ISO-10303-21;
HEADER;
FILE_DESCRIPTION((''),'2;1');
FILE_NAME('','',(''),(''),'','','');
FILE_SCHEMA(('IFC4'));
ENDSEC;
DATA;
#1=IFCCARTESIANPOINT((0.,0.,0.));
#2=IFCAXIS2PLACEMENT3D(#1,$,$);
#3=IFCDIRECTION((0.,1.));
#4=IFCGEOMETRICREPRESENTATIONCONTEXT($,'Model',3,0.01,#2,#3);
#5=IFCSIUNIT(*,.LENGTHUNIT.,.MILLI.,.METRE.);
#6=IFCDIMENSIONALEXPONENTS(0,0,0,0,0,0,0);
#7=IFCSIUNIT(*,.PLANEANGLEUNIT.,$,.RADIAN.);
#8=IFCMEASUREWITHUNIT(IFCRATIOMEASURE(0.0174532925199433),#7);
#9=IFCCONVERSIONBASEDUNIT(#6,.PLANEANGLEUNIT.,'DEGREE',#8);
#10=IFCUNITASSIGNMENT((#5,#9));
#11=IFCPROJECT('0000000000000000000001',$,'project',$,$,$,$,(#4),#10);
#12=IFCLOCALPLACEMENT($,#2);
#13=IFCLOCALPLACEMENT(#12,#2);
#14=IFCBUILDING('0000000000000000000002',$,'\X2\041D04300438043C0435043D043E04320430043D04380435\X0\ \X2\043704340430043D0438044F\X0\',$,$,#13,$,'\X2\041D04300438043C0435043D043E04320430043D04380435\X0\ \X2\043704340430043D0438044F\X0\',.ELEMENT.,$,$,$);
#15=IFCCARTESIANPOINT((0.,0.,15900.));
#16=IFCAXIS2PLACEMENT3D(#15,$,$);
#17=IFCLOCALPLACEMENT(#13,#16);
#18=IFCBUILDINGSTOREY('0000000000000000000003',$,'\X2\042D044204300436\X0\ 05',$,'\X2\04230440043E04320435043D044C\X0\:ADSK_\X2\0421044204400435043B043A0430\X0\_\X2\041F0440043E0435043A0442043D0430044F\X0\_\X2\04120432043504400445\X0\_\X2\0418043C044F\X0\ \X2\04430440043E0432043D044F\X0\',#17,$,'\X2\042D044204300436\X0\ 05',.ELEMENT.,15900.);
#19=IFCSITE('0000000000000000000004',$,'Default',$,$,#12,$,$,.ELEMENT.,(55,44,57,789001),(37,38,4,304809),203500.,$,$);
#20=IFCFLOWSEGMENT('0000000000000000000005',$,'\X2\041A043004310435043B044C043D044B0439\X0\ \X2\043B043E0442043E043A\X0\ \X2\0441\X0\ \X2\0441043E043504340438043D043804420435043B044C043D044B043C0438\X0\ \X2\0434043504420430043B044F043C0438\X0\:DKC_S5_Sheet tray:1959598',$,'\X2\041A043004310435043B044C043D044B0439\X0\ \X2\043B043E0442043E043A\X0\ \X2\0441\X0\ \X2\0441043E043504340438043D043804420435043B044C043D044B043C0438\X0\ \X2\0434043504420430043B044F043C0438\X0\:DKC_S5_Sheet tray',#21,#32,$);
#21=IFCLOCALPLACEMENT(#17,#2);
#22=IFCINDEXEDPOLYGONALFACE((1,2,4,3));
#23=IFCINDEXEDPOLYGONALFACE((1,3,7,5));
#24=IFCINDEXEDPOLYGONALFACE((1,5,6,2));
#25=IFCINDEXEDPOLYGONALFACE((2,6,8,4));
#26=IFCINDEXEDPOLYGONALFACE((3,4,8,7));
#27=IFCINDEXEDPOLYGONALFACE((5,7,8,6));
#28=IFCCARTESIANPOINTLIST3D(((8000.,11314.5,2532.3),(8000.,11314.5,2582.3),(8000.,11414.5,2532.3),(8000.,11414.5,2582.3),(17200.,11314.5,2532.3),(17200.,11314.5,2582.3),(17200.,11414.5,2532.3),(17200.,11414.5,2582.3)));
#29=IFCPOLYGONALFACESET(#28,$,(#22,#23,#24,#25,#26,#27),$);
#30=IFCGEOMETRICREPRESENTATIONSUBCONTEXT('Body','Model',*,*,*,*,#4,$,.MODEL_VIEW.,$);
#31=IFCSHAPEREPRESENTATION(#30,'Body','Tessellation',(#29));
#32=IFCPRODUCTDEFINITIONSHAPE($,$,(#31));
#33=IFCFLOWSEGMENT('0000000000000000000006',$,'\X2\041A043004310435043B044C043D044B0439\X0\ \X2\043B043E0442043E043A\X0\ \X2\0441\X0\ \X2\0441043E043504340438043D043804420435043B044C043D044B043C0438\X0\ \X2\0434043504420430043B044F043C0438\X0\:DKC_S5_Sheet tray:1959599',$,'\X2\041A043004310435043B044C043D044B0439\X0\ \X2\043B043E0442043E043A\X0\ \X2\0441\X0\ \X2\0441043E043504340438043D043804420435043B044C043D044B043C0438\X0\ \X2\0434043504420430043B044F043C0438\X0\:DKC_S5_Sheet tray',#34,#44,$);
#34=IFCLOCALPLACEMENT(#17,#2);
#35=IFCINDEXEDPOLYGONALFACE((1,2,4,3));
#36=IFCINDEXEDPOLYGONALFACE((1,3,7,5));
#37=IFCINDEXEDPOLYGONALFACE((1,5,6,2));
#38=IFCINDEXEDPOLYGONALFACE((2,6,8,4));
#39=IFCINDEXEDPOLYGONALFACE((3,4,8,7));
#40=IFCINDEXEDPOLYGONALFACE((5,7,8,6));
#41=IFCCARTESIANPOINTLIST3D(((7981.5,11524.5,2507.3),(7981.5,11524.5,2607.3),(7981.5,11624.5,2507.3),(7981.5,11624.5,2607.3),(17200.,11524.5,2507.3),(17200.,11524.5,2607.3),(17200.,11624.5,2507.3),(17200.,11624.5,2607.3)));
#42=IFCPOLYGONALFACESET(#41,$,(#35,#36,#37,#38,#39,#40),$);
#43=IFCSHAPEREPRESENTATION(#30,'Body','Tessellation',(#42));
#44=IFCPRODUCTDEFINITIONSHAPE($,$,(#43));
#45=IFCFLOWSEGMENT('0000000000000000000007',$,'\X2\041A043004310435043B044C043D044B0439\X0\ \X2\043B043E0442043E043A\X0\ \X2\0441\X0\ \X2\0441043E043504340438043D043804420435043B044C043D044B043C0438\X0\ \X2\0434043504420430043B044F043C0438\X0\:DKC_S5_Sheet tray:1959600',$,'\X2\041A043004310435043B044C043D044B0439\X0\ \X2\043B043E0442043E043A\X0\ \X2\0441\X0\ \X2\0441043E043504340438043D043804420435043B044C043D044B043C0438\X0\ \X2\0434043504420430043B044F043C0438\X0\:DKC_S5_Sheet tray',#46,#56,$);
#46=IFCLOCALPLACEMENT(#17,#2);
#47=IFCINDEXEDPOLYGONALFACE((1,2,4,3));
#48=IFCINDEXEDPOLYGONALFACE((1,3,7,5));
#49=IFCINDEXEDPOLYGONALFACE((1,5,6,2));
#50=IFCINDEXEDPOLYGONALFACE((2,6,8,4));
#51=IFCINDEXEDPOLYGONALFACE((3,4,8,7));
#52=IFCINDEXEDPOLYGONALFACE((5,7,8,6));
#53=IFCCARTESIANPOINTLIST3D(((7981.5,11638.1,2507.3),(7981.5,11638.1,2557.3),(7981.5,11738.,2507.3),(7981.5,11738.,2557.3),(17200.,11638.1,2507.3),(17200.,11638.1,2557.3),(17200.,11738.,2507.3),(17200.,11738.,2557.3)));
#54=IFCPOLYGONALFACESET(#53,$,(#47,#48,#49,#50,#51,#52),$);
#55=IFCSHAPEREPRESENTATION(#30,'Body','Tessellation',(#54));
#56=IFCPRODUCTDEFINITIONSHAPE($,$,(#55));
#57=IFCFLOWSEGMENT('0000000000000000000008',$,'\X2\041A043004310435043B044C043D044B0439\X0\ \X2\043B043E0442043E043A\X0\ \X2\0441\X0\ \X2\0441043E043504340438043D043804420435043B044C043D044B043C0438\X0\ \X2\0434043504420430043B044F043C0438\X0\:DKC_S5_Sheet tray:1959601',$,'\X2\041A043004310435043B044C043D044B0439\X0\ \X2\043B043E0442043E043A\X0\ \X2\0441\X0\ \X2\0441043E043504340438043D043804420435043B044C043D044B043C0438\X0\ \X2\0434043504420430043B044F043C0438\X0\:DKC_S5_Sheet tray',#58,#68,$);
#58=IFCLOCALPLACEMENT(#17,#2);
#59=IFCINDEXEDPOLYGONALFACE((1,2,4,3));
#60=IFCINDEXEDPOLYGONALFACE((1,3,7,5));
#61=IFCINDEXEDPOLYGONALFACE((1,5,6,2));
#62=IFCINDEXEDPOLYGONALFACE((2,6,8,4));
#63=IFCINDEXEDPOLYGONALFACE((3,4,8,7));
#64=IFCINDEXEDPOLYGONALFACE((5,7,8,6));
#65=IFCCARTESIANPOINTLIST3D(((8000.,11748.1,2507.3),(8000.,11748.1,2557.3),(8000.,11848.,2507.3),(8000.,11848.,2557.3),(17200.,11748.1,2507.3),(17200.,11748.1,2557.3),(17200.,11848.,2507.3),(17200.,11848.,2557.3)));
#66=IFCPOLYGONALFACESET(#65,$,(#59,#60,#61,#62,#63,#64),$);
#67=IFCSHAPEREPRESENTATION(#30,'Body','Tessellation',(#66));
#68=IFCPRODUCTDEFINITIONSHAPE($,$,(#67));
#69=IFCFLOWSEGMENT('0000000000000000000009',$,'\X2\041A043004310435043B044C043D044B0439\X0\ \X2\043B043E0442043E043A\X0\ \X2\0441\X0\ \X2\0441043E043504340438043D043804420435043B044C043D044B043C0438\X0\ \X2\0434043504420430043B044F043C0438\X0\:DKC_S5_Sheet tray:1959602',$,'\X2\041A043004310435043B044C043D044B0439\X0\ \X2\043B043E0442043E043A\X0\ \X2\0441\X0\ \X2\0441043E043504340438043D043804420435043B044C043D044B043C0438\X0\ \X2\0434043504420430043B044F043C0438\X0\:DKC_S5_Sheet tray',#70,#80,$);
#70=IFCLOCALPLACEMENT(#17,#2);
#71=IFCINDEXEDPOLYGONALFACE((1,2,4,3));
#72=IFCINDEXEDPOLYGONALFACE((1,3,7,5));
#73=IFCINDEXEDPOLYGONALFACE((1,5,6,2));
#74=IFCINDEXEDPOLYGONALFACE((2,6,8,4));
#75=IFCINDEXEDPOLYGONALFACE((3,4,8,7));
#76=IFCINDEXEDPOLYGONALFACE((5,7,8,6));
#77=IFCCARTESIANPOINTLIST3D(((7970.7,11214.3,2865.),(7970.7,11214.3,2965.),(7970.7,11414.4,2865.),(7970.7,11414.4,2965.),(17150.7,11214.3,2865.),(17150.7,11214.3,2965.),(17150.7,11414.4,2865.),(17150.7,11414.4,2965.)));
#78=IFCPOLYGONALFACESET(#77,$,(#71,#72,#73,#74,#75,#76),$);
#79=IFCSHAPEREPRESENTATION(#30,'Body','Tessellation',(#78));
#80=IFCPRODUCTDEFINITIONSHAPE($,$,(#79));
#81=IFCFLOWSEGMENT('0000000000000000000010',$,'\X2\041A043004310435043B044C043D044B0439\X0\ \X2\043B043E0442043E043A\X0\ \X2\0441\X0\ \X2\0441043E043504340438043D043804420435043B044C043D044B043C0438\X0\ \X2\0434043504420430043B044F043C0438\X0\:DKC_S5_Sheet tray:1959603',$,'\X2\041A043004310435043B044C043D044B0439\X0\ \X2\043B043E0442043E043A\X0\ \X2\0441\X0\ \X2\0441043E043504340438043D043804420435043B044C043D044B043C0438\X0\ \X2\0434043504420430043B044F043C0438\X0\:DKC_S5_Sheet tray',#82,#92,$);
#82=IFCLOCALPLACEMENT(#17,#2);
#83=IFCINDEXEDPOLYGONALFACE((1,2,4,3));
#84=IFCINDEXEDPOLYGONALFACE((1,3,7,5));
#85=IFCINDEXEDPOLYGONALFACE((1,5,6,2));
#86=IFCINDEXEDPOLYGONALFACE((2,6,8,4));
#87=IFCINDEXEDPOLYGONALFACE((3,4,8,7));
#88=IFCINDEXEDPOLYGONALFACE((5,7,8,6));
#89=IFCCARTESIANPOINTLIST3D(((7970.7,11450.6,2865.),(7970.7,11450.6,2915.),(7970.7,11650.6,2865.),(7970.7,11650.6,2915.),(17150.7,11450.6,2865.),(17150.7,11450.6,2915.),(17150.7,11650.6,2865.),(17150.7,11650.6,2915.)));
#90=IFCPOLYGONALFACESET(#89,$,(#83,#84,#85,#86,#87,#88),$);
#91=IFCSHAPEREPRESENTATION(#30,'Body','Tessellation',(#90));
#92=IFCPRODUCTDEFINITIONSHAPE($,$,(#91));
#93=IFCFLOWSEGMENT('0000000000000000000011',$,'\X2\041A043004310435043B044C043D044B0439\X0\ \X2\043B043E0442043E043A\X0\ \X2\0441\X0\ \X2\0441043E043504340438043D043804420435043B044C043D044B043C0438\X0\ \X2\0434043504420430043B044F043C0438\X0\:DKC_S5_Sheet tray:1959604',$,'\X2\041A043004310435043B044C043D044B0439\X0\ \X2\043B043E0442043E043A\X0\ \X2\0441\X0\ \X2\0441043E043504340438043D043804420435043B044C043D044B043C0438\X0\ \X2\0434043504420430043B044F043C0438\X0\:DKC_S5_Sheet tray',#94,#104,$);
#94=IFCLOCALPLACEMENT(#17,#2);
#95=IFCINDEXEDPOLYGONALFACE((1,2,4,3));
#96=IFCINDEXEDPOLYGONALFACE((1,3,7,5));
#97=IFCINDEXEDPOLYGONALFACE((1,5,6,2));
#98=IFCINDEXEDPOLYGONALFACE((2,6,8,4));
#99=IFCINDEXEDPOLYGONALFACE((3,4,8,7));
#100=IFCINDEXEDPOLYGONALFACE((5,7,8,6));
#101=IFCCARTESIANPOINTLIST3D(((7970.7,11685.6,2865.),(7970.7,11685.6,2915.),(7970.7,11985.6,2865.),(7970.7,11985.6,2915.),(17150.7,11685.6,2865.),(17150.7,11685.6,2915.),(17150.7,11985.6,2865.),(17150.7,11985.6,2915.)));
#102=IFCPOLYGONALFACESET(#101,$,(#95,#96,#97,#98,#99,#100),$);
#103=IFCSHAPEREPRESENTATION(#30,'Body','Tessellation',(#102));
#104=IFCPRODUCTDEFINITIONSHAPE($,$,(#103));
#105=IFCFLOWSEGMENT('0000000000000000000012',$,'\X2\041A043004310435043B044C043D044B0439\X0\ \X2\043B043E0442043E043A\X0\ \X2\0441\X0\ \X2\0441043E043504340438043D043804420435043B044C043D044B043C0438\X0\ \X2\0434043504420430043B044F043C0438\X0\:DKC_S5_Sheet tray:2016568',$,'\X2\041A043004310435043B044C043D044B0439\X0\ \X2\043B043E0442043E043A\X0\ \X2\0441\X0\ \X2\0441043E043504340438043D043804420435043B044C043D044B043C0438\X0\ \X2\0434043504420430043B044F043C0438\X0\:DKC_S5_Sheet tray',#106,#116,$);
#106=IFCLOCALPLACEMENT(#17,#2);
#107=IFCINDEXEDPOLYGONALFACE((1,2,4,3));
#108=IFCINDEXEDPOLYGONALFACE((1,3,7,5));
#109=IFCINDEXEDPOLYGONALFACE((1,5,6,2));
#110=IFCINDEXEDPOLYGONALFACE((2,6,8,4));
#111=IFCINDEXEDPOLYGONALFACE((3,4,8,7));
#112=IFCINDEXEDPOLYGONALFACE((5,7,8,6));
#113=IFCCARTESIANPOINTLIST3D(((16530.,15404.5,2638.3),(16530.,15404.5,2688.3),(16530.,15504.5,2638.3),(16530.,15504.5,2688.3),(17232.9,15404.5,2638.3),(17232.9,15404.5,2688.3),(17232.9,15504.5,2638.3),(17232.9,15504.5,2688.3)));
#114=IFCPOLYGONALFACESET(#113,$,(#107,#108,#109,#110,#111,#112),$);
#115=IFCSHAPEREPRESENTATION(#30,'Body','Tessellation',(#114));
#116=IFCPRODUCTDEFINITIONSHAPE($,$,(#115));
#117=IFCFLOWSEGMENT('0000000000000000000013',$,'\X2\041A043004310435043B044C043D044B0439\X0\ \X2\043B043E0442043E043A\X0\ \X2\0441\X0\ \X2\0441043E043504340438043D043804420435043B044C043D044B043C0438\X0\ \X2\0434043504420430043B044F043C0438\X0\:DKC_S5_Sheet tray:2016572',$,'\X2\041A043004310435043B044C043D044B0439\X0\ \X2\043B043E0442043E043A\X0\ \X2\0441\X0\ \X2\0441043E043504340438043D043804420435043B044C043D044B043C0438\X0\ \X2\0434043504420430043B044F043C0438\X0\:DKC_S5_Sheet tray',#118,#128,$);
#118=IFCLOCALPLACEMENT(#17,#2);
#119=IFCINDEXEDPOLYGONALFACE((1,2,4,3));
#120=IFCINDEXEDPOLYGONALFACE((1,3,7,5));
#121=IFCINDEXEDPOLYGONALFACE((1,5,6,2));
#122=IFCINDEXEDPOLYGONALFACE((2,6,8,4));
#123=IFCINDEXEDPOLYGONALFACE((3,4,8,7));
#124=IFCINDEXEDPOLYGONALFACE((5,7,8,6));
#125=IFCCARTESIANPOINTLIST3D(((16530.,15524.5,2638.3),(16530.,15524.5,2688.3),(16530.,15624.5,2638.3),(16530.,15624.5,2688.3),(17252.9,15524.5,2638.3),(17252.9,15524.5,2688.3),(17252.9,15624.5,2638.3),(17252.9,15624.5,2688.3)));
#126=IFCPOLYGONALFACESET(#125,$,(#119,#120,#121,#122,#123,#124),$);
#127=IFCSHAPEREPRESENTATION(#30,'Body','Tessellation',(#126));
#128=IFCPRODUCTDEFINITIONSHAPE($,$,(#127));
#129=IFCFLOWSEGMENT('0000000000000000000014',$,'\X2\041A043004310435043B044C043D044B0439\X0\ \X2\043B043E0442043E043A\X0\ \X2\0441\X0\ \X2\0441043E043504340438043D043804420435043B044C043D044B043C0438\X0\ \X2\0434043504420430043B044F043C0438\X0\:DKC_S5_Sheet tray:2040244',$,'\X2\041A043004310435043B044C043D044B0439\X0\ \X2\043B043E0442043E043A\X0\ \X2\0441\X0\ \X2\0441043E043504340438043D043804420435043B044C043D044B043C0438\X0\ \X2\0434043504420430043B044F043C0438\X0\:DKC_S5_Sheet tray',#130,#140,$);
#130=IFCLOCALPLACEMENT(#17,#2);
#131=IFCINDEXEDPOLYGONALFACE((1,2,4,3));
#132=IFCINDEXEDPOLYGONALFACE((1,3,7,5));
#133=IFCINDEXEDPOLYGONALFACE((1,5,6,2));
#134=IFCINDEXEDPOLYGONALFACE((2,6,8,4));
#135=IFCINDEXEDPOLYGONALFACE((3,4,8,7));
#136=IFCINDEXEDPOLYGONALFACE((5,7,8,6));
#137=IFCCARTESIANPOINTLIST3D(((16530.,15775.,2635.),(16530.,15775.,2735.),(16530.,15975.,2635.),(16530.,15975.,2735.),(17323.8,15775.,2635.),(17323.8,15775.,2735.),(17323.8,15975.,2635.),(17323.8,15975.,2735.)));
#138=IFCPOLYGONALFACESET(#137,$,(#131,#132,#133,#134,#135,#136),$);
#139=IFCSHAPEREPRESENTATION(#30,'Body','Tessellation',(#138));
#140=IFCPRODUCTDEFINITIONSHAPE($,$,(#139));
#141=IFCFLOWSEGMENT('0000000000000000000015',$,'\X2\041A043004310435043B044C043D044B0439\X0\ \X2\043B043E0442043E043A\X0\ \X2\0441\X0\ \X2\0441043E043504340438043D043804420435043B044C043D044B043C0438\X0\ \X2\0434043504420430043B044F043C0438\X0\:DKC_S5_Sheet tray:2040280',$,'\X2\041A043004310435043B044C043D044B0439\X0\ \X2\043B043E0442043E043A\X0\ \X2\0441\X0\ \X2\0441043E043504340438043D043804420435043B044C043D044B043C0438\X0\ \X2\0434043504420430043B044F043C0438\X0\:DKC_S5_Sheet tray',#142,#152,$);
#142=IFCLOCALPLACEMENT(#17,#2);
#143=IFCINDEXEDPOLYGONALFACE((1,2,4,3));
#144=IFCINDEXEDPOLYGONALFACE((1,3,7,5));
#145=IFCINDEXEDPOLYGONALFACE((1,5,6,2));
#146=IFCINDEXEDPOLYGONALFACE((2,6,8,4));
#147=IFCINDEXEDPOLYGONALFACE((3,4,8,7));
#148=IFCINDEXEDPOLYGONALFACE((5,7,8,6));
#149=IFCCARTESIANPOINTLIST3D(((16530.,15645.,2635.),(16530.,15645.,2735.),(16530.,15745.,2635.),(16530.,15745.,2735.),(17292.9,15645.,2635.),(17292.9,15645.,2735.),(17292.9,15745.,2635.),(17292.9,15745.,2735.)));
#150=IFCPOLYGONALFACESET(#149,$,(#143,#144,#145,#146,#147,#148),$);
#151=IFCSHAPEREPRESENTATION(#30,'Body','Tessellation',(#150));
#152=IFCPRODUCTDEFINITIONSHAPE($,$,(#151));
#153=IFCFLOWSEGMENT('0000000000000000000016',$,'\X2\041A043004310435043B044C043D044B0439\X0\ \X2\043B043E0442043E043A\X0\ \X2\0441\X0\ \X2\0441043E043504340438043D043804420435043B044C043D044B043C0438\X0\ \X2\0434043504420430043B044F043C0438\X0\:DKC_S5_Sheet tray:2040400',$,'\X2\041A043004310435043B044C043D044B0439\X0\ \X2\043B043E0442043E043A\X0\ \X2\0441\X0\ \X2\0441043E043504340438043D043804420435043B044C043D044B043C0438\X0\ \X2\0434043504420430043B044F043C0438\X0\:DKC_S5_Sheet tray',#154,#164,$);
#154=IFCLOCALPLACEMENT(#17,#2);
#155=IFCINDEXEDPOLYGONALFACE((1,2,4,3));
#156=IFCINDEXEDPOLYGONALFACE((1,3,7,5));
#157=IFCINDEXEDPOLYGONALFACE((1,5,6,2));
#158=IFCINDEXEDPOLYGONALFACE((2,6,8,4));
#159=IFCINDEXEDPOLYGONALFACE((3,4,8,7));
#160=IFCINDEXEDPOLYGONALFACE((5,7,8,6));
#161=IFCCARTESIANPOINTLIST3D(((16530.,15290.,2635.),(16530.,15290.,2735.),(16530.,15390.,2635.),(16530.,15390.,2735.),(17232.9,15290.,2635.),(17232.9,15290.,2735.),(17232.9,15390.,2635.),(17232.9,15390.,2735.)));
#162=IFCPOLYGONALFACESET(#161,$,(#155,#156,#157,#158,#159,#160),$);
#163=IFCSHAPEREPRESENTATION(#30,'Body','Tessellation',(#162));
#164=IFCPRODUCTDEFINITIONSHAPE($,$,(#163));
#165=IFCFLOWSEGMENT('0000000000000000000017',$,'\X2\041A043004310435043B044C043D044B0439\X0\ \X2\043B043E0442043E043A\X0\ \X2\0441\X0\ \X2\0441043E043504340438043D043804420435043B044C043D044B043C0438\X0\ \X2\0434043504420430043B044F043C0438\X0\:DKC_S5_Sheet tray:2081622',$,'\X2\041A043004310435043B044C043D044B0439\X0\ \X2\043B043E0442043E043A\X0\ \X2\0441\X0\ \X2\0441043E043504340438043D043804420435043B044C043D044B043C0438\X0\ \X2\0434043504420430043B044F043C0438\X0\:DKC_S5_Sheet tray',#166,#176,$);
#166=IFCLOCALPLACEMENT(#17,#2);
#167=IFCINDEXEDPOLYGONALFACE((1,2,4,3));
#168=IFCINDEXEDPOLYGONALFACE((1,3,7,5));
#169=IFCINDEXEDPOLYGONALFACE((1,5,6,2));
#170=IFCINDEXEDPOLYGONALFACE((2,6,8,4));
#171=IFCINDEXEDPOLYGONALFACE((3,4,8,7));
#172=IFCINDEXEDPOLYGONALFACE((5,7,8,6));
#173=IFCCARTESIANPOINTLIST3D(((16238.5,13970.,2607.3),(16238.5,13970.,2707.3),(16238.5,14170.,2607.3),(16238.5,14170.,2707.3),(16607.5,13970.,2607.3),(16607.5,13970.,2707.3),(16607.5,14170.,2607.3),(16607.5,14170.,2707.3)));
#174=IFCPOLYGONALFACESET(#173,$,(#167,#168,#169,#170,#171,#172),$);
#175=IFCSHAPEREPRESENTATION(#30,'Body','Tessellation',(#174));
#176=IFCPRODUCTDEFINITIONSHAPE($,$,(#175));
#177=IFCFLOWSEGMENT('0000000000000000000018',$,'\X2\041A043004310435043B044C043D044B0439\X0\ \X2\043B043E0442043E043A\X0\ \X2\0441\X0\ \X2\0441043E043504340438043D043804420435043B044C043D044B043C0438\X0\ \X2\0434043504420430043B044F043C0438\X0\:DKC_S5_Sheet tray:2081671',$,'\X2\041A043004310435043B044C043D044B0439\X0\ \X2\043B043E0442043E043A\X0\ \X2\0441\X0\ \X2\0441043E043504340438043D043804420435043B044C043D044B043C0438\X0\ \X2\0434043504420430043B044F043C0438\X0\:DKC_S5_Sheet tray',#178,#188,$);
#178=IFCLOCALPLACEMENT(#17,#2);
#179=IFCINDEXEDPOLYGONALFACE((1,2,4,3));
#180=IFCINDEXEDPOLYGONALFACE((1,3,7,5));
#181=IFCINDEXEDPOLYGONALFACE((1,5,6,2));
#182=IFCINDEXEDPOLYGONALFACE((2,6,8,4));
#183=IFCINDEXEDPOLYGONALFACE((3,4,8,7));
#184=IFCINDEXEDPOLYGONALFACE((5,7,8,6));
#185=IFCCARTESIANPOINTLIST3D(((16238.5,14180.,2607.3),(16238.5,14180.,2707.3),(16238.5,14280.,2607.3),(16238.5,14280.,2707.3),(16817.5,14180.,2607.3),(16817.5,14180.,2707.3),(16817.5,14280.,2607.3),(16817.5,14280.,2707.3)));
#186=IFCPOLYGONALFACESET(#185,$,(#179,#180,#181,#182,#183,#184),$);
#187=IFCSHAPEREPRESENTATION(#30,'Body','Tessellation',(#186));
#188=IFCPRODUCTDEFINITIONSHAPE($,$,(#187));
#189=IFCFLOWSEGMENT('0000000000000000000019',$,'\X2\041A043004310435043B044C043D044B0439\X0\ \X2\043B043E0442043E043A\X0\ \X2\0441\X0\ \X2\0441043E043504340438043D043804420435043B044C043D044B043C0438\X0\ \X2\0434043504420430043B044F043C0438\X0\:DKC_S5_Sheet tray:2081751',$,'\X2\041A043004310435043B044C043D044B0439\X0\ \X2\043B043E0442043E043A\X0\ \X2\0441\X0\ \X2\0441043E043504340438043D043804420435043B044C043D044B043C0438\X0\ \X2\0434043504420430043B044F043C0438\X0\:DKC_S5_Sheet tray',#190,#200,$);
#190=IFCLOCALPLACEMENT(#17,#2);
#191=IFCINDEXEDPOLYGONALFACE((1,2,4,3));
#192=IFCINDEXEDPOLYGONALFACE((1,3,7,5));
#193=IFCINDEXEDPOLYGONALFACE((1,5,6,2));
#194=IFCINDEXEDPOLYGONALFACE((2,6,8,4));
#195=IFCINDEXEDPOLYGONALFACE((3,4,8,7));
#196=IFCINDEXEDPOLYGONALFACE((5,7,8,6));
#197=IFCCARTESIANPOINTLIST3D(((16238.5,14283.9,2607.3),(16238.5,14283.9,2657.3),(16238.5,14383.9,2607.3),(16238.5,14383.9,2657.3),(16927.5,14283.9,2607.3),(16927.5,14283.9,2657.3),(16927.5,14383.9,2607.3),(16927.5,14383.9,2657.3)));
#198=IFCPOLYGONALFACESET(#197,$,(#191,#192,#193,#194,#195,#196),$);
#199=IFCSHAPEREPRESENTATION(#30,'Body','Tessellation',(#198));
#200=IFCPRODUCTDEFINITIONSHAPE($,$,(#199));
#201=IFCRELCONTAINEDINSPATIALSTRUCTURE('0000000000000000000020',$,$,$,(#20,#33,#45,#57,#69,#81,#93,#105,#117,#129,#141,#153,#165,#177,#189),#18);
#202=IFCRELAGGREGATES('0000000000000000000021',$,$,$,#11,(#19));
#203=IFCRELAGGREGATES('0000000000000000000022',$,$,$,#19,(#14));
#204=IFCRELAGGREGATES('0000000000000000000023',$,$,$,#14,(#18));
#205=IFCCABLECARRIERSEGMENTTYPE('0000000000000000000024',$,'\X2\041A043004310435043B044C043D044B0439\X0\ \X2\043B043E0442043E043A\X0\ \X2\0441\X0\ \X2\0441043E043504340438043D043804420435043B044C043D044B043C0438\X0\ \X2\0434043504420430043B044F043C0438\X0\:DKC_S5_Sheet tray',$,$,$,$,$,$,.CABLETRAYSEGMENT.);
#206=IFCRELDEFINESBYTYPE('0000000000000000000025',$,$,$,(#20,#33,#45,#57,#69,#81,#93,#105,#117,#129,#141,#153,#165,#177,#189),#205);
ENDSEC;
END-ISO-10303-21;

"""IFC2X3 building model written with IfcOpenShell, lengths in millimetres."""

from ifc_helpers import new_model, entity, si_unit, converted_unit, direction, frame, origin, origin_2d_with_axis, place, context, subcontext, project, spatial, rectangle, extrude, type_object, element, save


model = new_model("IFC2X3")

# Units and contexts
model_context = context("Model", 3, precision=0.01, world=origin(), true_north=direction((0.0, 1.0)))
body_context = subcontext(model_context, "Body", "Model", "MODEL_VIEW")
ifc_project = project(units=[si_unit("LENGTHUNIT", "METRE", prefix="MILLI"), converted_unit("PLANEANGLEUNIT", "DEGREE", entity("IfcRatioMeasure", 0.0174532925199433), si_unit("PLANEANGLEUNIT", "RADIAN"), dimensions=[0, 0, 0, 0, 0, 0, 0])], contexts=[model_context])

# Site, building, storey
site_placement = place(None, origin())
site = spatial("IfcSite", under=ifc_project, at=site_placement, Name="Default", CompositionType="ELEMENT", RefLatitude=(55, 44, 57, 789001), RefLongitude=(37, 38, 4, 304809), RefElevation=203500.0)
building_placement = place(site_placement, origin())
building = spatial("IfcBuilding", under=site, at=building_placement, Name="Наименование здания", LongName="Наименование здания", CompositionType="ELEMENT")
storey_placement = place(building_placement, frame((0.0, 0.0, 15900.0)))
storey = spatial("IfcBuildingStorey", under=building, at=storey_placement, Name="Этаж 05", ObjectType="Уровень:ADSK_Стрелка_Проектная_Вверх_Имя уровня", LongName="Этаж 05", CompositionType="ELEMENT", Elevation=15900.0)

# Flow segments
cable_carrier_segment_type_1 = type_object("IfcCableCarrierSegmentType", Name="Кабельный лоток с соединительными деталями:DKC_S5_Sheet tray", PredefinedType="CABLETRAYSEGMENT")
flow_segment_1_placement = place(storey_placement, frame((8000.0, 11314.5, 2532.3)))
element("IfcFlowSegment", 1, at=flow_segment_1_placement, inside=storey, type_object=cable_carrier_segment_type_1, Name="Кабельный лоток с соединительными деталями:DKC_S5_Sheet tray:1959598", ObjectType="Кабельный лоток с соединительными деталями:DKC_S5_Sheet tray", context=body_context, shape_type="SweptSolid", body=[
    extrude(rectangle(XDim=9200.0, YDim=100.0, at=origin_2d_with_axis()), frame((4600.0, 50.0, 0.0)), (0.0, 0.0, 1.0), 50.0),
])
flow_segment_2_placement = place(storey_placement, frame((7981.5, 11524.5, 2507.3)))
element("IfcFlowSegment", 2, at=flow_segment_2_placement, inside=storey, type_object=cable_carrier_segment_type_1, Name="Кабельный лоток с соединительными деталями:DKC_S5_Sheet tray:1959599", ObjectType="Кабельный лоток с соединительными деталями:DKC_S5_Sheet tray", context=body_context, shape_type="SweptSolid", body=[
    extrude(rectangle(XDim=9218.5, YDim=100.0, at=origin_2d_with_axis()), frame((4609.2, 50.0, 0.0)), (0.0, 0.0, 1.0), 100.0),
])
flow_segment_3_placement = place(storey_placement, frame((7981.5, 11638.0, 2507.3)))
element("IfcFlowSegment", 3, at=flow_segment_3_placement, inside=storey, type_object=cable_carrier_segment_type_1, Name="Кабельный лоток с соединительными деталями:DKC_S5_Sheet tray:1959600", ObjectType="Кабельный лоток с соединительными деталями:DKC_S5_Sheet tray", context=body_context, shape_type="SweptSolid", body=[
    extrude(rectangle(XDim=9218.5, YDim=100.0, at=origin_2d_with_axis()), frame((4609.2, 50.0, 0.0)), (0.0, 0.0, 1.0), 50.0),
])
flow_segment_4_placement = place(storey_placement, frame((8000.0, 11748.0, 2507.3)))
element("IfcFlowSegment", 4, at=flow_segment_4_placement, inside=storey, type_object=cable_carrier_segment_type_1, Name="Кабельный лоток с соединительными деталями:DKC_S5_Sheet tray:1959601", ObjectType="Кабельный лоток с соединительными деталями:DKC_S5_Sheet tray", context=body_context, shape_type="SweptSolid", body=[
    extrude(rectangle(XDim=9200.0, YDim=100.0, at=origin_2d_with_axis()), frame((4600.0, 50.0, 0.0)), (0.0, 0.0, 1.0), 50.0),
])
flow_segment_5_placement = place(storey_placement, frame((7970.7, 11214.4, 2865.0)))
element("IfcFlowSegment", 5, at=flow_segment_5_placement, inside=storey, type_object=cable_carrier_segment_type_1, Name="Кабельный лоток с соединительными деталями:DKC_S5_Sheet tray:1959602", ObjectType="Кабельный лоток с соединительными деталями:DKC_S5_Sheet tray", context=body_context, shape_type="SweptSolid", body=[
    extrude(rectangle(XDim=9180.0, YDim=200.0, at=origin_2d_with_axis()), frame((4590.0, 100.0, 0.0)), (0.0, 0.0, 1.0), 100.0),
])
flow_segment_6_placement = place(storey_placement, frame((7970.7, 11450.6, 2865.0)))
element("IfcFlowSegment", 6, at=flow_segment_6_placement, inside=storey, type_object=cable_carrier_segment_type_1, Name="Кабельный лоток с соединительными деталями:DKC_S5_Sheet tray:1959603", ObjectType="Кабельный лоток с соединительными деталями:DKC_S5_Sheet tray", context=body_context, shape_type="SweptSolid", body=[
    extrude(rectangle(XDim=9180.0, YDim=200.0, at=origin_2d_with_axis()), frame((4590.0, 100.0, 0.0)), (0.0, 0.0, 1.0), 50.0),
])
flow_segment_7_placement = place(storey_placement, frame((7970.7, 11685.6, 2865.0)))
element("IfcFlowSegment", 7, at=flow_segment_7_placement, inside=storey, type_object=cable_carrier_segment_type_1, Name="Кабельный лоток с соединительными деталями:DKC_S5_Sheet tray:1959604", ObjectType="Кабельный лоток с соединительными деталями:DKC_S5_Sheet tray", context=body_context, shape_type="SweptSolid", body=[
    extrude(rectangle(XDim=9180.0, YDim=300.0, at=origin_2d_with_axis()), frame((4590.0, 150.0, 0.0)), (0.0, 0.0, 1.0), 50.0),
])
flow_segment_8_placement = place(storey_placement, frame((16530.0, 15404.5, 2638.3)))
element("IfcFlowSegment", 8, at=flow_segment_8_placement, inside=storey, type_object=cable_carrier_segment_type_1, Name="Кабельный лоток с соединительными деталями:DKC_S5_Sheet tray:2016568", ObjectType="Кабельный лоток с соединительными деталями:DKC_S5_Sheet tray", context=body_context, shape_type="SweptSolid", body=[
    extrude(rectangle(XDim=702.9, YDim=100.0, at=origin_2d_with_axis()), frame((351.4, 50.0, 0.0), z_axis=(0.0, 0.0, 1.0), x_axis=(-1.0, 0.0, 0.0)), (0.0, 0.0, 1.0), 50.0),
])
flow_segment_9_placement = place(storey_placement, frame((16530.0, 15524.5, 2638.3)))
element("IfcFlowSegment", 9, at=flow_segment_9_placement, inside=storey, type_object=cable_carrier_segment_type_1, Name="Кабельный лоток с соединительными деталями:DKC_S5_Sheet tray:2016572", ObjectType="Кабельный лоток с соединительными деталями:DKC_S5_Sheet tray", context=body_context, shape_type="SweptSolid", body=[
    extrude(rectangle(XDim=722.9, YDim=100.0, at=origin_2d_with_axis()), frame((361.4, 50.0, 0.0), z_axis=(0.0, 0.0, 1.0), x_axis=(-1.0, 0.0, 0.0)), (0.0, 0.0, 1.0), 50.0),
])
flow_segment_10_placement = place(storey_placement, frame((16530.0, 15775.0, 2635.0)))
element("IfcFlowSegment", 10, at=flow_segment_10_placement, inside=storey, type_object=cable_carrier_segment_type_1, Name="Кабельный лоток с соединительными деталями:DKC_S5_Sheet tray:2040244", ObjectType="Кабельный лоток с соединительными деталями:DKC_S5_Sheet tray", context=body_context, shape_type="SweptSolid", body=[
    extrude(rectangle(XDim=793.8, YDim=200.0, at=origin_2d_with_axis()), frame((396.9, 100.0, 0.0), z_axis=(0.0, 0.0, 1.0), x_axis=(-1.0, 0.0, 0.0)), (0.0, 0.0, 1.0), 100.0),
])
flow_segment_11_placement = place(storey_placement, frame((16530.0, 15645.0, 2635.0)))
element("IfcFlowSegment", 11, at=flow_segment_11_placement, inside=storey, type_object=cable_carrier_segment_type_1, Name="Кабельный лоток с соединительными деталями:DKC_S5_Sheet tray:2040280", ObjectType="Кабельный лоток с соединительными деталями:DKC_S5_Sheet tray", context=body_context, shape_type="SweptSolid", body=[
    extrude(rectangle(XDim=762.9, YDim=100.0, at=origin_2d_with_axis()), frame((381.4, 50.0, 0.0), z_axis=(0.0, 0.0, 1.0), x_axis=(-1.0, 0.0, 0.0)), (0.0, 0.0, 1.0), 100.0),
])
flow_segment_12_placement = place(storey_placement, frame((16530.0, 15290.0, 2635.0)))
element("IfcFlowSegment", 12, at=flow_segment_12_placement, inside=storey, type_object=cable_carrier_segment_type_1, Name="Кабельный лоток с соединительными деталями:DKC_S5_Sheet tray:2040400", ObjectType="Кабельный лоток с соединительными деталями:DKC_S5_Sheet tray", context=body_context, shape_type="SweptSolid", body=[
    extrude(rectangle(XDim=702.9, YDim=100.0, at=origin_2d_with_axis()), frame((351.4, 50.0, 0.0), z_axis=(0.0, 0.0, 1.0), x_axis=(-1.0, 0.0, 0.0)), (0.0, 0.0, 1.0), 100.0),
])
flow_segment_13_placement = place(storey_placement, frame((16238.5, 13970.0, 2607.3)))
element("IfcFlowSegment", 13, at=flow_segment_13_placement, inside=storey, type_object=cable_carrier_segment_type_1, Name="Кабельный лоток с соединительными деталями:DKC_S5_Sheet tray:2081622", ObjectType="Кабельный лоток с соединительными деталями:DKC_S5_Sheet tray", context=body_context, shape_type="SweptSolid", body=[
    extrude(rectangle(XDim=369.0, YDim=200.0, at=origin_2d_with_axis()), frame((184.5, 100.0, 0.0), z_axis=(0.0, 0.0, 1.0), x_axis=(-1.0, 0.0, 0.0)), (0.0, 0.0, 1.0), 100.0),
])
flow_segment_14_placement = place(storey_placement, frame((16238.5, 14180.0, 2607.3)))
element("IfcFlowSegment", 14, at=flow_segment_14_placement, inside=storey, type_object=cable_carrier_segment_type_1, Name="Кабельный лоток с соединительными деталями:DKC_S5_Sheet tray:2081671", ObjectType="Кабельный лоток с соединительными деталями:DKC_S5_Sheet tray", context=body_context, shape_type="SweptSolid", body=[
    extrude(rectangle(XDim=579.0, YDim=100.0, at=origin_2d_with_axis()), frame((289.5, 50.0, 0.0), z_axis=(0.0, 0.0, 1.0), x_axis=(-1.0, 0.0, 0.0)), (0.0, 0.0, 1.0), 100.0),
])
flow_segment_15_placement = place(storey_placement, frame((16238.5, 14283.9, 2607.3)))
element("IfcFlowSegment", 15, at=flow_segment_15_placement, inside=storey, type_object=cable_carrier_segment_type_1, Name="Кабельный лоток с соединительными деталями:DKC_S5_Sheet tray:2081751", ObjectType="Кабельный лоток с соединительными деталями:DKC_S5_Sheet tray", context=body_context, shape_type="SweptSolid", body=[
    extrude(rectangle(XDim=689.0, YDim=100.0, at=origin_2d_with_axis()), frame((344.5, 50.0, 0.0), z_axis=(0.0, 0.0, 1.0), x_axis=(-1.0, 0.0, 0.0)), (0.0, 0.0, 1.0), 50.0),
])

save(model, "model.ifc")
